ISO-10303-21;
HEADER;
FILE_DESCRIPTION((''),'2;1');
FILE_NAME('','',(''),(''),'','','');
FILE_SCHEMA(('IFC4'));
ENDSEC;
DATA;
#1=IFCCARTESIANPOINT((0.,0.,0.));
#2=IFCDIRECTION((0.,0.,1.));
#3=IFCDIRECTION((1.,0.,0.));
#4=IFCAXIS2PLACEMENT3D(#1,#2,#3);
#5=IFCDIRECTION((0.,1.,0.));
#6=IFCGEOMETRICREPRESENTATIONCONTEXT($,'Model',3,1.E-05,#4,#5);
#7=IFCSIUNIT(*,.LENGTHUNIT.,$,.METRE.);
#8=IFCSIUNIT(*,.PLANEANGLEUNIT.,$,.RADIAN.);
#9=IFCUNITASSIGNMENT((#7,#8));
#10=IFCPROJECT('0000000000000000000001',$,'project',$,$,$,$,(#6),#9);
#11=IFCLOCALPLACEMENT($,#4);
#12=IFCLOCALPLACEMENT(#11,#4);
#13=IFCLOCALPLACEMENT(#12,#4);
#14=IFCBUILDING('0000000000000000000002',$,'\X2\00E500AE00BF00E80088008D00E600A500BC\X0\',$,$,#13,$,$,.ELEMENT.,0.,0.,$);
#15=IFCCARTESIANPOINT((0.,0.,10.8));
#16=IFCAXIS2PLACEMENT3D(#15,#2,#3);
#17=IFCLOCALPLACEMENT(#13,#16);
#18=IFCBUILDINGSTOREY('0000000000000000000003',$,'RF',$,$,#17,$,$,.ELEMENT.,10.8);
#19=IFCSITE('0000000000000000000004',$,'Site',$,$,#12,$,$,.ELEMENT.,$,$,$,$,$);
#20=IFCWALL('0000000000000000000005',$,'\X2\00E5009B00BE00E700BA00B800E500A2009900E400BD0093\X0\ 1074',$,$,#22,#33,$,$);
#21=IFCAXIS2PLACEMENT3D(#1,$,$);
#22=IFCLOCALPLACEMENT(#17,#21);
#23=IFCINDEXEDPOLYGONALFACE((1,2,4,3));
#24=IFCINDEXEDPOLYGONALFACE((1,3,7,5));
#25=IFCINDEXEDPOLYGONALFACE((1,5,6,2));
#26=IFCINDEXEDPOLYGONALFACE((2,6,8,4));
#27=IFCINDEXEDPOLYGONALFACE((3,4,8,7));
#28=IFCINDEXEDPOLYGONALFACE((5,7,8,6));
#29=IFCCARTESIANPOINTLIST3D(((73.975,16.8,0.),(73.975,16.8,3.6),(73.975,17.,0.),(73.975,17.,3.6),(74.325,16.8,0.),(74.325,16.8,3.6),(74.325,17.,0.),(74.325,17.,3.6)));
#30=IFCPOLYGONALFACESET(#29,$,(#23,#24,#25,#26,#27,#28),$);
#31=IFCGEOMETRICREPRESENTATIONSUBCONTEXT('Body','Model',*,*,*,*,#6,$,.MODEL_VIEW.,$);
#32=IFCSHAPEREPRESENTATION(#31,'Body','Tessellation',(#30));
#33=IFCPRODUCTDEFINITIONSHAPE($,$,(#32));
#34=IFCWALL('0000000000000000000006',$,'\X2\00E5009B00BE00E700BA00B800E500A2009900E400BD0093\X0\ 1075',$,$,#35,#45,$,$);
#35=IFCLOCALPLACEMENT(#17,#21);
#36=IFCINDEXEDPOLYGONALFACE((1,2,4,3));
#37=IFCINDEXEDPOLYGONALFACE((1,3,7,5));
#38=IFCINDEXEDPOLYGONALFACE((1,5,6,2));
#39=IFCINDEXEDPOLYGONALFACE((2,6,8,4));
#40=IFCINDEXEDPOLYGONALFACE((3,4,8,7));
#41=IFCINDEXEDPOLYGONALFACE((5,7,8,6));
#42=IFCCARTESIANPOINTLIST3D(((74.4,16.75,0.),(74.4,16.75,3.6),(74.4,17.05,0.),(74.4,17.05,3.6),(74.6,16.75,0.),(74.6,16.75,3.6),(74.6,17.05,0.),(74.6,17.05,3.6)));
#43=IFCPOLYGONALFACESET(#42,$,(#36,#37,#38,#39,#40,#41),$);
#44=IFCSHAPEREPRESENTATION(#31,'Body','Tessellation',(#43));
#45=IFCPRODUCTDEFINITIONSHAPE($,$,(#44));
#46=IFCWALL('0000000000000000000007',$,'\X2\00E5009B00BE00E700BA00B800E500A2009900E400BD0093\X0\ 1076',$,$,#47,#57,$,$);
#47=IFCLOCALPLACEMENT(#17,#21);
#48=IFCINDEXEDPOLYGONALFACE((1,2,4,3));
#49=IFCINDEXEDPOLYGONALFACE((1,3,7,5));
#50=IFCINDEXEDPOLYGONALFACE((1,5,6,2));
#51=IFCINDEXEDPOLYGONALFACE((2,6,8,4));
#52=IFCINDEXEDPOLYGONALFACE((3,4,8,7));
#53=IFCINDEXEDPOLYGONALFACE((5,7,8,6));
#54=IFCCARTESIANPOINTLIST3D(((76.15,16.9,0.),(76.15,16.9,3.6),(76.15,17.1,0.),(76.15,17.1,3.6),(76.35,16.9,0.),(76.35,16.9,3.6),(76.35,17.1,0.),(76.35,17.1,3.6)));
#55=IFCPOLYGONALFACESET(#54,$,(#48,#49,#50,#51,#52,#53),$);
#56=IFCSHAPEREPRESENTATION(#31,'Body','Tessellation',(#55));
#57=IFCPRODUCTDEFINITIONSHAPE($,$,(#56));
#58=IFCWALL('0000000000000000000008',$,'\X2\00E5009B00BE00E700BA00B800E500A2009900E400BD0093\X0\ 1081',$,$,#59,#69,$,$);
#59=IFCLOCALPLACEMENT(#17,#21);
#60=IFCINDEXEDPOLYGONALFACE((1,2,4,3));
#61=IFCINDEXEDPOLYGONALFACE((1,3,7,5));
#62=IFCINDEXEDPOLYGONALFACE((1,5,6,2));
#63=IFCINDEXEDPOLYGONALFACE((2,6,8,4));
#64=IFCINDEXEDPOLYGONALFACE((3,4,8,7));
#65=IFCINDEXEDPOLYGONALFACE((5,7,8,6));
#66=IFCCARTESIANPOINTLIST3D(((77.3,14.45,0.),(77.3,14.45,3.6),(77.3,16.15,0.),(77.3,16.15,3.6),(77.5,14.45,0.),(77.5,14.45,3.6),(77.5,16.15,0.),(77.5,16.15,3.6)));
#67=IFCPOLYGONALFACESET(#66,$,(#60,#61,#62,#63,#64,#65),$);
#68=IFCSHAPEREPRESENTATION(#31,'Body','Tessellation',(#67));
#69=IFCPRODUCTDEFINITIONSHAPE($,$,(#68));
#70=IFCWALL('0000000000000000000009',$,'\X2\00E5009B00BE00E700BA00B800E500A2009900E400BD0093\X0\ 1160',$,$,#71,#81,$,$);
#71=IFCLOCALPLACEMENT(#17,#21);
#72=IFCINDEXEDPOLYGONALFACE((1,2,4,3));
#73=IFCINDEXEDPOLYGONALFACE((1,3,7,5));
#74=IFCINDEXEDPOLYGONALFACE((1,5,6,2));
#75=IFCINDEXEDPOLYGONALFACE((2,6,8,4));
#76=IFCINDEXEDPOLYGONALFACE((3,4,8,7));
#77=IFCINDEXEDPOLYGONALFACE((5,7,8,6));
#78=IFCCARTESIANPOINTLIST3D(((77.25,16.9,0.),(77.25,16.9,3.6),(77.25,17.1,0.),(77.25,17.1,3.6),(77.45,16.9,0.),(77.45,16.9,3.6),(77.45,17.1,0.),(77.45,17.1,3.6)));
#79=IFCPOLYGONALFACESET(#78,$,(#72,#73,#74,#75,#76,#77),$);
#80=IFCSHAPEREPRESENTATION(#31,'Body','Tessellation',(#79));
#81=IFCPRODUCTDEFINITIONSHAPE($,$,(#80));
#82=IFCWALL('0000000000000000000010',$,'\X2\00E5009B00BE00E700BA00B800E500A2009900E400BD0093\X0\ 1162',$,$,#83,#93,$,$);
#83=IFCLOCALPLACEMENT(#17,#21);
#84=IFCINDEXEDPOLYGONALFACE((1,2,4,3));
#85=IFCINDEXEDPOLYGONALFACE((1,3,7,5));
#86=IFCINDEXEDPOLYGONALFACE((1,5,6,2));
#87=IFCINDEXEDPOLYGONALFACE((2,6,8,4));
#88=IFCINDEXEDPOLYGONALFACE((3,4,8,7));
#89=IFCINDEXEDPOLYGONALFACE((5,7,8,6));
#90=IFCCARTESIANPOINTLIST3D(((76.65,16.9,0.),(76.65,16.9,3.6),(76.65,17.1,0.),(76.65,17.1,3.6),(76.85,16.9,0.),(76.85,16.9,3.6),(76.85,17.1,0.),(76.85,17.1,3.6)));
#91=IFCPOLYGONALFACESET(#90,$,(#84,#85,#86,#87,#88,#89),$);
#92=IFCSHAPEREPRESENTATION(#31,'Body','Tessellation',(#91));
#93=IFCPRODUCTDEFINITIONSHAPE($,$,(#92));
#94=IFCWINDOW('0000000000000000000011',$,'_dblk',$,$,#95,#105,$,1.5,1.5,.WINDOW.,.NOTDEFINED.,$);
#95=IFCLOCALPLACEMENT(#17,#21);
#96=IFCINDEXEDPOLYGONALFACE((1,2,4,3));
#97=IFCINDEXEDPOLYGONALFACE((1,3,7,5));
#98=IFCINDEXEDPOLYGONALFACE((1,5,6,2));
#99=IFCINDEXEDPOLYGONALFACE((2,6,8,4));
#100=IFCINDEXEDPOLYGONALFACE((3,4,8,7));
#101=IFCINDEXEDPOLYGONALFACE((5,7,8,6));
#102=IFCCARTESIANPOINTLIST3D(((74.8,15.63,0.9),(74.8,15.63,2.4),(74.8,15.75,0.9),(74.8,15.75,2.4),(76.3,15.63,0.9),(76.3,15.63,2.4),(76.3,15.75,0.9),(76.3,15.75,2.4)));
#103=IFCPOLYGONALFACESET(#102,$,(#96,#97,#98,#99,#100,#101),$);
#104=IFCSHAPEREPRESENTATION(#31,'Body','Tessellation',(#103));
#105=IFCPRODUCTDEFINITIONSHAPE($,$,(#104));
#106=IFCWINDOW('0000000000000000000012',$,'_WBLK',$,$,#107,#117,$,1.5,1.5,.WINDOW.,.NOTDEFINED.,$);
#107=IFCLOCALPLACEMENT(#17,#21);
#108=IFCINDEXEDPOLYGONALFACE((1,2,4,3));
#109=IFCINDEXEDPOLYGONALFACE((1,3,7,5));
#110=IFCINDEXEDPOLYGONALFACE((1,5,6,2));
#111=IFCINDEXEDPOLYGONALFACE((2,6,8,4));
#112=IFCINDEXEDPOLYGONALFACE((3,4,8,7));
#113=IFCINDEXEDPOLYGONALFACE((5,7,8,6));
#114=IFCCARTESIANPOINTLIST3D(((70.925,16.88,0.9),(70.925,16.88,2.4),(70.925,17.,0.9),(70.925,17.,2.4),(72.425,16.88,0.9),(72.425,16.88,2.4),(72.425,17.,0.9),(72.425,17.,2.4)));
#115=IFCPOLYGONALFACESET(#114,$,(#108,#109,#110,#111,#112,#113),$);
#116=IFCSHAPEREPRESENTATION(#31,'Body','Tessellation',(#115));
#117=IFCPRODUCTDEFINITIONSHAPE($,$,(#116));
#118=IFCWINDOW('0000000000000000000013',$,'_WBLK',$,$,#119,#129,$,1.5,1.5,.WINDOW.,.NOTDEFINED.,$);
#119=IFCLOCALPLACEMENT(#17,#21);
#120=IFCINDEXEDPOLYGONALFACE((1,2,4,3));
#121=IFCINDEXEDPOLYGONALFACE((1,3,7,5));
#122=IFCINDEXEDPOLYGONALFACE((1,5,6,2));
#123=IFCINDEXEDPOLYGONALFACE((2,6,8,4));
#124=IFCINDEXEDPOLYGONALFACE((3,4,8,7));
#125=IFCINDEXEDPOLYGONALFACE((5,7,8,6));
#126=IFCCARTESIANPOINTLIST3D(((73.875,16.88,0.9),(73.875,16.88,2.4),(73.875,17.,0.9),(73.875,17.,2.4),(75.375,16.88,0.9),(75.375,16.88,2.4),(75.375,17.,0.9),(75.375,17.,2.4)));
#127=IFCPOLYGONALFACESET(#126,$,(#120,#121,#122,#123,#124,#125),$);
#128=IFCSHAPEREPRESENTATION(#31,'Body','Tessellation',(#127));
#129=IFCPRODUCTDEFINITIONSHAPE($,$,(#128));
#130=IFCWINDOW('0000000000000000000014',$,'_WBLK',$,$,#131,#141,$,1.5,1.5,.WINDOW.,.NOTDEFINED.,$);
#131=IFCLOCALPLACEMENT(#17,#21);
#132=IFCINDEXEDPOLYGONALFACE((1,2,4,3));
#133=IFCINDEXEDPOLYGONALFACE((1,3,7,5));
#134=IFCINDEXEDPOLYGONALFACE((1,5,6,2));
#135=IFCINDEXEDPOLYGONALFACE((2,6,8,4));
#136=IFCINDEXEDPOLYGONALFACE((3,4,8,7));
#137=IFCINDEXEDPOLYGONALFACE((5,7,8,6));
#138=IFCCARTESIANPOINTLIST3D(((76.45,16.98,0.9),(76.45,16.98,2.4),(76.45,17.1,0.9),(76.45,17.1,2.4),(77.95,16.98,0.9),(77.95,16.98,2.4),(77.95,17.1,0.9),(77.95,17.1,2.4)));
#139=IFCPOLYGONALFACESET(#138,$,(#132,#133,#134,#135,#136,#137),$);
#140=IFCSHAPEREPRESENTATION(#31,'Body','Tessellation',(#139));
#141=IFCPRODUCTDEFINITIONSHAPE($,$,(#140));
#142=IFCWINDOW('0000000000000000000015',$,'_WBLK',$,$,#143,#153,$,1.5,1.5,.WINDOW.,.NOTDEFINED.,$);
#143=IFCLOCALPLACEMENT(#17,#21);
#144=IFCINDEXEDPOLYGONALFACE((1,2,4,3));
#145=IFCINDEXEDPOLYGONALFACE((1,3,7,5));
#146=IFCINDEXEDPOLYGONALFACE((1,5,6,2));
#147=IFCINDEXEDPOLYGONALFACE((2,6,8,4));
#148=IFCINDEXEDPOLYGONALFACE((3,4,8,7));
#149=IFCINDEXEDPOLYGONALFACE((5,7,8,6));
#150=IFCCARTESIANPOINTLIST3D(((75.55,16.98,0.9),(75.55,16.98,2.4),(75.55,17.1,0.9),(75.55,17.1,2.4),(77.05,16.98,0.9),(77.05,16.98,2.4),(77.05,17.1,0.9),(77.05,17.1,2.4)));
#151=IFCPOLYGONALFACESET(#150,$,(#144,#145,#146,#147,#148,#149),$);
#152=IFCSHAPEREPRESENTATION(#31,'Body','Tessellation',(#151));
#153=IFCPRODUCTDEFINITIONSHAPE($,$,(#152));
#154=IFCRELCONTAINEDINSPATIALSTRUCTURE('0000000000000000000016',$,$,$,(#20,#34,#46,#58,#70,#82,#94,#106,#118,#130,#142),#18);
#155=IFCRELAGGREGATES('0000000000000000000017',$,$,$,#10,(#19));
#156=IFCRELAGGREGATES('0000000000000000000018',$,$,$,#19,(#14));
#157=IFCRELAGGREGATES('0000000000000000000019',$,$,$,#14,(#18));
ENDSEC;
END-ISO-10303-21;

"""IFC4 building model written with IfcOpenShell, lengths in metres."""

from ifc_helpers import new_model, si_unit, direction, frame, frame_2d, origin_with_axes, place, context, subcontext, project, spatial, rectangle, extrude, element, save


model = new_model("IFC4")

# Units and contexts
model_context = context("Model", 3, precision=1e-05, world=origin_with_axes(), true_north=direction((0.0, 1.0, 0.0)))
body_context = subcontext(model_context, "Body", "Model", "MODEL_VIEW")
ifc_project = project(units=[si_unit("LENGTHUNIT", "METRE"), si_unit("PLANEANGLEUNIT", "RADIAN")], contexts=[model_context])

# Site, building, storey
placement = place(None, origin_with_axes())
site_placement = place(placement, origin_with_axes())
site = spatial("IfcSite", under=ifc_project, at=site_placement, Name="Site", CompositionType="ELEMENT")
building_placement = place(site_placement, origin_with_axes())
building = spatial("IfcBuilding", under=site, at=building_placement, Name="å®¿è\u0088\u008dæ¥¼", CompositionType="ELEMENT", ElevationOfRefHeight=0.0, ElevationOfTerrain=0.0)
storey_placement = place(building_placement, frame((0.0, 0.0, 10.8), z_axis=(0.0, 0.0, 1.0), x_axis=(1.0, 0.0, 0.0)))
storey = spatial("IfcBuildingStorey", under=building, at=storey_placement, Name="RF", CompositionType="ELEMENT", Elevation=10.8)

# Walls
for number, where, z_axis, x_axis, name in (
    (1, (74.15, 16.9, 0.0), (0.0, 0.0, 1.0), (1.0, 0.0, 0.0), "å\u009b¾çº¸å¢\u0099ä½\u0093 1074"),
):
    element("IfcWall", number, at=place(storey_placement, frame(where, z_axis=z_axis, x_axis=x_axis)), inside=storey, Name=name, context=body_context, shape_type="SweptSolid", body=[
        extrude(rectangle(XDim=0.35, YDim=0.2, at=frame_2d((0.0, 0.0), x_axis=(1.0, 0.0, 0.0))), frame((0.0, 0.0, 0.0), z_axis=(0.0, 0.0, 1.0)), (0.0, 0.0, 1.0), 3.6),
    ])
wall_1_placement = place(storey_placement, frame((74.5, 16.9, 0.0), z_axis=(0.0, 0.0, 1.0), x_axis=(0.0, 1.0, 0.0)))
element("IfcWall", 2, at=wall_1_placement, inside=storey, Name="å\u009b¾çº¸å¢\u0099ä½\u0093 1075", context=body_context, shape_type="SweptSolid", body=[
    extrude(rectangle(XDim=0.3, YDim=0.2, at=frame_2d((0.0, 0.0), x_axis=(1.0, 0.0, 0.0))), frame((0.0, 0.0, 0.0), z_axis=(0.0, 0.0, 1.0)), (0.0, 0.0, 1.0), 3.6),
])
wall_2_placement = place(storey_placement, frame((76.25, 17.0, 0.0), z_axis=(0.0, 0.0, 1.0), x_axis=(0.0, 1.0, 0.0)))
element("IfcWall", 3, at=wall_2_placement, inside=storey, Name="å\u009b¾çº¸å¢\u0099ä½\u0093 1076", context=body_context, shape_type="SweptSolid", body=[
    extrude(rectangle(XDim=0.2, YDim=0.2, at=frame_2d((0.0, 0.0), x_axis=(1.0, 0.0, 0.0))), frame((0.0, 0.0, 0.0), z_axis=(0.0, 0.0, 1.0)), (0.0, 0.0, 1.0), 3.6),
])
wall_3_placement = place(storey_placement, frame((77.4, 15.3, 0.0), z_axis=(0.0, 0.0, 1.0), x_axis=(0.0, 1.0, 0.0)))
element("IfcWall", 4, at=wall_3_placement, inside=storey, Name="å\u009b¾çº¸å¢\u0099ä½\u0093 1081", context=body_context, shape_type="SweptSolid", body=[
    extrude(rectangle(XDim=1.7, YDim=0.2, at=frame_2d((0.0, 0.0), x_axis=(1.0, 0.0, 0.0))), frame((0.0, 0.0, 0.0), z_axis=(0.0, 0.0, 1.0)), (0.0, 0.0, 1.0), 3.6),
])
for number, where, z_axis, x_axis, name in (
    (5, (77.35, 17.0, 0.0), (0.0, 0.0, 1.0), (1.0, 0.0, 0.0), "å\u009b¾çº¸å¢\u0099ä½\u0093 1160"),
    (6, (76.75, 17.0, 0.0), (0.0, 0.0, 1.0), (0.0, 1.0, 0.0), "å\u009b¾çº¸å¢\u0099ä½\u0093 1162"),
):
    element("IfcWall", number, at=place(storey_placement, frame(where, z_axis=z_axis, x_axis=x_axis)), inside=storey, Name=name, context=body_context, shape_type="SweptSolid", body=[
        extrude(rectangle(XDim=0.2, YDim=0.2, at=frame_2d((0.0, 0.0), x_axis=(1.0, 0.0, 0.0))), frame((0.0, 0.0, 0.0), z_axis=(0.0, 0.0, 1.0)), (0.0, 0.0, 1.0), 3.6),
    ])

# Windows
for number, where, z_axis, x_axis, name in (
    (7, (75.55, 15.69, 0.9), (0.0, 0.0, 1.0), (1.0, 0.0, 0.0), "_dblk"),
    (8, (71.675, 16.94, 0.9), (0.0, 0.0, 1.0), (1.0, 0.0, 0.0), "_WBLK"),
    (9, (74.625, 16.94, 0.9), (0.0, 0.0, 1.0), (1.0, 0.0, 0.0), "_WBLK"),
    (10, (77.2, 17.04, 0.9), (0.0, 0.0, 1.0), (1.0, 0.0, 0.0), "_WBLK"),
    (11, (76.3, 17.04, 0.9), (0.0, 0.0, 1.0), (1.0, 0.0, 0.0), "_WBLK"),
):
    element("IfcWindow", number, at=place(storey_placement, frame(where, z_axis=z_axis, x_axis=x_axis)), inside=storey, Name=name, OverallHeight=1.5, OverallWidth=1.5, PartitioningType="NOTDEFINED", PredefinedType="WINDOW", context=body_context, shape_type="SweptSolid", body=[
        extrude(rectangle(XDim=1.5, YDim=0.12, at=frame_2d((0.0, 0.0), x_axis=(1.0, 0.0, 0.0))), frame((0.0, 0.0, 0.0), z_axis=(0.0, 0.0, 1.0)), (0.0, 0.0, 1.0), 1.5),
    ])

save(model, "model.ifc")
